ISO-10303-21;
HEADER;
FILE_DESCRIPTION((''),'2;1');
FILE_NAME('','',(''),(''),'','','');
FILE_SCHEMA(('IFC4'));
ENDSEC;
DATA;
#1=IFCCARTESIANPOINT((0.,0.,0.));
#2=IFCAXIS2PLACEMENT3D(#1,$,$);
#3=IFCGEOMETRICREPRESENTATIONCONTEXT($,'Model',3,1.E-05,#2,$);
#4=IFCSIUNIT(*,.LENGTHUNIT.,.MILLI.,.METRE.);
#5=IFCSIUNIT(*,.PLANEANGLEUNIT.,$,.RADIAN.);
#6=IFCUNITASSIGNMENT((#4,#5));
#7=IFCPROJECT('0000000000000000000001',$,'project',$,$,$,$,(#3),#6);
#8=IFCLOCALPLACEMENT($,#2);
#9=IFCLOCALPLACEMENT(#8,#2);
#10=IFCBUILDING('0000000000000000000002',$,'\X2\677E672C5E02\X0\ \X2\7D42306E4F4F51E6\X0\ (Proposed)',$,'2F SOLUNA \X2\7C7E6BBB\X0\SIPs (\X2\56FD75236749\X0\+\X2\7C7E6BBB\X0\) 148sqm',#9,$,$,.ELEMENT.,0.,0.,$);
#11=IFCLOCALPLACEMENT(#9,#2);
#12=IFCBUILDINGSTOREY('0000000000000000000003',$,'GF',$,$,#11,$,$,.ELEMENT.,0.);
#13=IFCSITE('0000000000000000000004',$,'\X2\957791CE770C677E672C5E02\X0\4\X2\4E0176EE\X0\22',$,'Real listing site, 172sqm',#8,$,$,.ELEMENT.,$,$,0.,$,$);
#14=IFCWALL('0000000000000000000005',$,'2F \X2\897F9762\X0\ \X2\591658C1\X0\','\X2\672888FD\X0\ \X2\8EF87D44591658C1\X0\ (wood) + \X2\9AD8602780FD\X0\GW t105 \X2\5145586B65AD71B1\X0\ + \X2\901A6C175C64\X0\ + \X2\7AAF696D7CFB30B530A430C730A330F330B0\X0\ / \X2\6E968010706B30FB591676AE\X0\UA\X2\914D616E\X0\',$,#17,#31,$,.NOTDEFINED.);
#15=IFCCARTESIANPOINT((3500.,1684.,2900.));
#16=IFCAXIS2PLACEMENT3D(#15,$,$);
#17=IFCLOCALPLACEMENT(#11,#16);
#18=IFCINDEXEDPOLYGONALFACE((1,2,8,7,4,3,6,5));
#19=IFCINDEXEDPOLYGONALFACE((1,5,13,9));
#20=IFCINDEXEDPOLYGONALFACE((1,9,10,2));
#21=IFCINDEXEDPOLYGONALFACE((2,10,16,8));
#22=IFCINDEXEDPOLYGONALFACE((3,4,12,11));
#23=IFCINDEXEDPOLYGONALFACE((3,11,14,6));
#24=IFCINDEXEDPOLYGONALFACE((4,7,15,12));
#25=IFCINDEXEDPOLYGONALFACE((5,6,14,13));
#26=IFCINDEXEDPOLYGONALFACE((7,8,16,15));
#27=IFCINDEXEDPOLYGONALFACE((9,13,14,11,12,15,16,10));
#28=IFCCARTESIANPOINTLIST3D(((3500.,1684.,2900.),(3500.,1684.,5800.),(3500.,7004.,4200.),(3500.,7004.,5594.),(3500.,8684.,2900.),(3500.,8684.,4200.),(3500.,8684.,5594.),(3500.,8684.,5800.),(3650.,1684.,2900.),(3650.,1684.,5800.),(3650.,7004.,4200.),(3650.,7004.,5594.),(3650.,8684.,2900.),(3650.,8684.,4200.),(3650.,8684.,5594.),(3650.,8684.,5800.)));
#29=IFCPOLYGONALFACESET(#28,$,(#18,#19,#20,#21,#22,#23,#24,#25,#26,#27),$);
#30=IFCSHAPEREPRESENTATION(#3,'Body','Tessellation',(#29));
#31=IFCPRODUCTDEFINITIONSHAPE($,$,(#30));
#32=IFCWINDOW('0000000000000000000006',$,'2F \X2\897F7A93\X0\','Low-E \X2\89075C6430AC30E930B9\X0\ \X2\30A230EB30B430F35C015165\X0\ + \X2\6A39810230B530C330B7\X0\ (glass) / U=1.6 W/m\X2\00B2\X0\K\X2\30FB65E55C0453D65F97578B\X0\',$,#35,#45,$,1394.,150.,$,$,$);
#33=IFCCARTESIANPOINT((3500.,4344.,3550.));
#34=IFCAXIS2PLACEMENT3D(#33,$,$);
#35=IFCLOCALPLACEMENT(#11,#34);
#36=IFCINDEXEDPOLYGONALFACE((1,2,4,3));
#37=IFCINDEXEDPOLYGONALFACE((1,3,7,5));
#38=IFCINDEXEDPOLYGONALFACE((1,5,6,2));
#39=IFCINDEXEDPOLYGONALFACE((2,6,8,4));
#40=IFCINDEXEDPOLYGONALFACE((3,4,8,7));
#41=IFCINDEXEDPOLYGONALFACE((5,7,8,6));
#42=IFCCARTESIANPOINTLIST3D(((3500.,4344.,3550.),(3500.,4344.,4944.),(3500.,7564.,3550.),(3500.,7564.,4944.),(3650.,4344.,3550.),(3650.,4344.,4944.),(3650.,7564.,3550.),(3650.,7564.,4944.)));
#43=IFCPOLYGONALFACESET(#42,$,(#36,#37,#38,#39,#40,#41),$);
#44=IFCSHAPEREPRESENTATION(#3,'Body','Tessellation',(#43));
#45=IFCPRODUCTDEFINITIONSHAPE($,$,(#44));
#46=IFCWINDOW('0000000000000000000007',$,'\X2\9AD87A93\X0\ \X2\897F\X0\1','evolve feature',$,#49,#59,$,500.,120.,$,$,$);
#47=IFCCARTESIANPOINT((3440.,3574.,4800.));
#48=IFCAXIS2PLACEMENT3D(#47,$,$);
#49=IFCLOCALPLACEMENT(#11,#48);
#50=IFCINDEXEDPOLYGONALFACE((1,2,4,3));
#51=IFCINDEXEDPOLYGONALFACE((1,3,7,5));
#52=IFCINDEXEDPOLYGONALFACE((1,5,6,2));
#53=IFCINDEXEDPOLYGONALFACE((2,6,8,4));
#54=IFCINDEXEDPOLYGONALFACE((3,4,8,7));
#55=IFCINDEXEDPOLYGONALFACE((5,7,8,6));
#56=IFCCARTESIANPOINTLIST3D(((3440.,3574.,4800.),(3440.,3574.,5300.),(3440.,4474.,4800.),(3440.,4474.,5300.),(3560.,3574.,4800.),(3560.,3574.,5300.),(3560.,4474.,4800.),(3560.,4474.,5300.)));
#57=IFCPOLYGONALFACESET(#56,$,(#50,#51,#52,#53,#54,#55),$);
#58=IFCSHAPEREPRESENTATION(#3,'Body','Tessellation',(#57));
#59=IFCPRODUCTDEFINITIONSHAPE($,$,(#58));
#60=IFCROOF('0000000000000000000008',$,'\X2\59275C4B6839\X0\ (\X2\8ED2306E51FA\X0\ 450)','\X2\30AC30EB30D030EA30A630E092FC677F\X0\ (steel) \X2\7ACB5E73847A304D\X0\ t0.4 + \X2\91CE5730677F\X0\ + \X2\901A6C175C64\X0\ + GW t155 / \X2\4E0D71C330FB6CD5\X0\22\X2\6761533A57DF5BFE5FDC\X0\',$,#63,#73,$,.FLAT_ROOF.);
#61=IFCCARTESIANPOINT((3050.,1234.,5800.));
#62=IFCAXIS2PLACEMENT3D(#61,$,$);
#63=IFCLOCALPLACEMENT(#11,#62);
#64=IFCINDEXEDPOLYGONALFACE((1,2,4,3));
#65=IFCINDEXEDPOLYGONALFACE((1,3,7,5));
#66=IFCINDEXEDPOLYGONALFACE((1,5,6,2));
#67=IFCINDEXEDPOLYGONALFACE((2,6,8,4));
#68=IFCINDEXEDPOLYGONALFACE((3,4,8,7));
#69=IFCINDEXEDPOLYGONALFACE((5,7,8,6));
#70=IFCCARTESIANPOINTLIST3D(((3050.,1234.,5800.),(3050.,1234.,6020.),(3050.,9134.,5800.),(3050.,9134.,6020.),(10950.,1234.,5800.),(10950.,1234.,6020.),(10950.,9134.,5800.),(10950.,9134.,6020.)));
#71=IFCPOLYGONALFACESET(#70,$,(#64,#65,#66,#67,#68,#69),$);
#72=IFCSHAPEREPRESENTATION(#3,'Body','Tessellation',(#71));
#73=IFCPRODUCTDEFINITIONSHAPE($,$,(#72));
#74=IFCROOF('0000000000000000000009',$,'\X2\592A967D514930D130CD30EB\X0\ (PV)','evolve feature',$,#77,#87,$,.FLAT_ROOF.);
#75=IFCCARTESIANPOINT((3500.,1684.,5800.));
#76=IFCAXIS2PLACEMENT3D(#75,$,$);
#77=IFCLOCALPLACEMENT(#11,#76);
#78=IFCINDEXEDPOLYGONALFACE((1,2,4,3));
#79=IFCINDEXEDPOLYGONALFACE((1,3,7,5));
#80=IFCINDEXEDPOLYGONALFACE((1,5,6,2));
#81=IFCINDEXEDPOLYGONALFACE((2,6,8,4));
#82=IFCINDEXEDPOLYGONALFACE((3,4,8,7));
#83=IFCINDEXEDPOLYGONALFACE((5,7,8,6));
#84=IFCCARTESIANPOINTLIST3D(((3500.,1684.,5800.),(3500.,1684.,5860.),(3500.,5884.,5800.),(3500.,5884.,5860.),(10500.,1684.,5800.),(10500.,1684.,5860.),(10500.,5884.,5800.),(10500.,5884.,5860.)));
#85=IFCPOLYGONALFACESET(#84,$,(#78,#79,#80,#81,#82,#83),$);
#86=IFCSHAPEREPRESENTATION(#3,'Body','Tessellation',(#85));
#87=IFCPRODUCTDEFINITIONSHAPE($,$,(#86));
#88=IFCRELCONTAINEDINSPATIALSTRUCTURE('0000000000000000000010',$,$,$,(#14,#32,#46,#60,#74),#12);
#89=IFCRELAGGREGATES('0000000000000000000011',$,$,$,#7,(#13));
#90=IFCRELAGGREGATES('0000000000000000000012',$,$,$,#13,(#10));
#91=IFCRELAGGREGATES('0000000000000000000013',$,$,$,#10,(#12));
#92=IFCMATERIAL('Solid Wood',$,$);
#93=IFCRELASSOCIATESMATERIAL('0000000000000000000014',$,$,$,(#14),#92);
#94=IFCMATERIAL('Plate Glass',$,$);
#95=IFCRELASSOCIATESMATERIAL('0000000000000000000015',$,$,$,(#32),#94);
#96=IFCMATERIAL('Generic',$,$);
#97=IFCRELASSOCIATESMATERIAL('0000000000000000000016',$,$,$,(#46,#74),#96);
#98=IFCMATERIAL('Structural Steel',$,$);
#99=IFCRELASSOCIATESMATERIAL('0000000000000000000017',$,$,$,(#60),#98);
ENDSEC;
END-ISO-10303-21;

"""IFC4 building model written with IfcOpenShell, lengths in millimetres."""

from ifc_helpers import new_model, si_unit, frame, frame_2d, origin, place, context, project, spatial, rectangle, extrude, material, element, fill, save


model = new_model("IFC4")

# Units and contexts
model_context = context("Model", 3, precision=1e-05, world=origin())
ifc_project = project(units=[si_unit("LENGTHUNIT", "METRE", prefix="MILLI"), si_unit("PLANEANGLEUNIT", "RADIAN")], contexts=[model_context])

# Site, building, storey
site_placement = place(None, origin())
site = spatial("IfcSite", under=ifc_project, at=site_placement, Name="長野県松本市4丁目22", ObjectType="Real listing site, 172sqm", CompositionType="ELEMENT", RefElevation=0.0)
building_placement = place(site_placement, origin())
building = spatial("IfcBuilding", under=site, at=building_placement, Name="松本市 終の住処 (Proposed)", ObjectType="2F SOLUNA 籾殻SIPs (国産杉+籾殻) 148sqm", CompositionType="ELEMENT", ElevationOfRefHeight=0.0, ElevationOfTerrain=0.0)
storey_placement = place(building_placement, origin())
storey = spatial("IfcBuildingStorey", under=building, at=storey_placement, Name="GF", CompositionType="ELEMENT", Elevation=0.0)

# Shared definitions
ifc_material_1 = material(Name="Solid Wood")
ifc_material_2 = material(Name="Generic")

# Shared definitions
ifc_material_3 = material(Name="Plate Glass")

# Wall, openings, windows
wall_1_placement = place(storey_placement, frame((3500.0, 1684.0, 2900.0)))
wall_1 = element("IfcWall", 1, at=wall_1_placement, inside=storey, material=ifc_material_1, Name="2F 西面 外壁", Description="木製 軸組外壁 (wood) + 高性能GW t105 充填断熱 + 通気層 + 窯業系サイディング / 準耐火・外皮UA配慮", PredefinedType="NOTDEFINED", context=model_context, shape_type="SweptSolid", body=[
    extrude(rectangle(XDim=150.0, YDim=7000.0, at=frame_2d((75.0, 3500.0))), frame((3500.0, 1684.0, 2900.0)), (0.0, 0.0, 1.0), 2900.0),
])
opening_1_placement = place(storey_placement, frame((3500.0, 4344.0, 3550.0)))
opening_1 = element("IfcOpeningElement", 2, at=opening_1_placement, cuts=wall_1, PredefinedType="NOTDEFINED", context=model_context, shape_type="SweptSolid", body=[
    extrude(rectangle(XDim=150.0, YDim=3220.0, at=frame_2d((75.0, 1610.0))), frame((3500.0, 4344.0, 3550.0)), (0.0, 0.0, 1.0), 1394.0),
])
opening_2_placement = place(storey_placement, frame((3440.0, 3574.0, 4800.0)))
opening_2 = element("IfcOpeningElement", 3, at=opening_2_placement, cuts=wall_1, PredefinedType="NOTDEFINED", context=model_context, shape_type="SweptSolid", body=[
    extrude(rectangle(XDim=120.0, YDim=900.0, at=frame_2d((60.0, 450.0))), frame((3440.0, 3574.0, 4800.0)), (0.0, 0.0, 1.0), 500.0),
])
window_1_placement = place(storey_placement, frame((3500.0, 4344.0, 3550.0)))
window_1 = element("IfcWindow", 4, at=window_1_placement, inside=storey, material=ifc_material_3, Name="2F 西窓", Description="Low-E 複層ガラス アルゴン封入 + 樹脂サッシ (glass) / U=1.6 W/m²K・日射取得型", OverallHeight=1394.0, OverallWidth=150.0, context=model_context, shape_type="SweptSolid", body=[
    extrude(rectangle(XDim=150.0, YDim=3220.0, at=frame_2d((75.0, 1610.0))), frame((3500.0, 4344.0, 3550.0)), (0.0, 0.0, 1.0), 1394.0),
])
fill(opening_1, window_1)
window_2_placement = place(storey_placement, frame((3440.0, 3574.0, 4800.0)))
window_2 = element("IfcWindow", 5, at=window_2_placement, inside=storey, material=ifc_material_2, Name="高窓 西1", Description="evolve feature", OverallHeight=500.0, OverallWidth=120.0, context=model_context, shape_type="SweptSolid", body=[
    extrude(rectangle(XDim=120.0, YDim=900.0, at=frame_2d((60.0, 450.0))), frame((3440.0, 3574.0, 4800.0)), (0.0, 0.0, 1.0), 500.0),
])
fill(opening_2, window_2)

# Roofs
ifc_material_4 = material(Name="Structural Steel")
roof_1_placement = place(storey_placement, frame((3050.0, 1234.0, 5800.0)))
element("IfcRoof", 6, at=roof_1_placement, inside=storey, material=ifc_material_4, Name="大屋根 (軒の出 450)", Description="ガルバリウム鋼板 (steel) 立平葺き t0.4 + 野地板 + 通気層 + GW t155 / 不燃・法22条区域対応", PredefinedType="FLAT_ROOF", context=model_context, shape_type="SweptSolid", body=[
    extrude(rectangle(XDim=7900.0, YDim=7900.0, at=frame_2d((3950.0, 3950.0))), frame((3050.0, 1234.0, 5800.0)), (0.0, 0.0, 1.0), 220.0),
])
roof_2_placement = place(storey_placement, frame((3500.0, 1684.0, 5800.0)))
element("IfcRoof", 7, at=roof_2_placement, inside=storey, material=ifc_material_2, Name="太陽光パネル (PV)", Description="evolve feature", PredefinedType="FLAT_ROOF", context=model_context, shape_type="SweptSolid", body=[
    extrude(rectangle(XDim=7000.0, YDim=4200.0, at=frame_2d((3500.0, 2100.0))), frame((3500.0, 1684.0, 5800.0)), (0.0, 0.0, 1.0), 60.0),
])

save(model, "model.ifc")
